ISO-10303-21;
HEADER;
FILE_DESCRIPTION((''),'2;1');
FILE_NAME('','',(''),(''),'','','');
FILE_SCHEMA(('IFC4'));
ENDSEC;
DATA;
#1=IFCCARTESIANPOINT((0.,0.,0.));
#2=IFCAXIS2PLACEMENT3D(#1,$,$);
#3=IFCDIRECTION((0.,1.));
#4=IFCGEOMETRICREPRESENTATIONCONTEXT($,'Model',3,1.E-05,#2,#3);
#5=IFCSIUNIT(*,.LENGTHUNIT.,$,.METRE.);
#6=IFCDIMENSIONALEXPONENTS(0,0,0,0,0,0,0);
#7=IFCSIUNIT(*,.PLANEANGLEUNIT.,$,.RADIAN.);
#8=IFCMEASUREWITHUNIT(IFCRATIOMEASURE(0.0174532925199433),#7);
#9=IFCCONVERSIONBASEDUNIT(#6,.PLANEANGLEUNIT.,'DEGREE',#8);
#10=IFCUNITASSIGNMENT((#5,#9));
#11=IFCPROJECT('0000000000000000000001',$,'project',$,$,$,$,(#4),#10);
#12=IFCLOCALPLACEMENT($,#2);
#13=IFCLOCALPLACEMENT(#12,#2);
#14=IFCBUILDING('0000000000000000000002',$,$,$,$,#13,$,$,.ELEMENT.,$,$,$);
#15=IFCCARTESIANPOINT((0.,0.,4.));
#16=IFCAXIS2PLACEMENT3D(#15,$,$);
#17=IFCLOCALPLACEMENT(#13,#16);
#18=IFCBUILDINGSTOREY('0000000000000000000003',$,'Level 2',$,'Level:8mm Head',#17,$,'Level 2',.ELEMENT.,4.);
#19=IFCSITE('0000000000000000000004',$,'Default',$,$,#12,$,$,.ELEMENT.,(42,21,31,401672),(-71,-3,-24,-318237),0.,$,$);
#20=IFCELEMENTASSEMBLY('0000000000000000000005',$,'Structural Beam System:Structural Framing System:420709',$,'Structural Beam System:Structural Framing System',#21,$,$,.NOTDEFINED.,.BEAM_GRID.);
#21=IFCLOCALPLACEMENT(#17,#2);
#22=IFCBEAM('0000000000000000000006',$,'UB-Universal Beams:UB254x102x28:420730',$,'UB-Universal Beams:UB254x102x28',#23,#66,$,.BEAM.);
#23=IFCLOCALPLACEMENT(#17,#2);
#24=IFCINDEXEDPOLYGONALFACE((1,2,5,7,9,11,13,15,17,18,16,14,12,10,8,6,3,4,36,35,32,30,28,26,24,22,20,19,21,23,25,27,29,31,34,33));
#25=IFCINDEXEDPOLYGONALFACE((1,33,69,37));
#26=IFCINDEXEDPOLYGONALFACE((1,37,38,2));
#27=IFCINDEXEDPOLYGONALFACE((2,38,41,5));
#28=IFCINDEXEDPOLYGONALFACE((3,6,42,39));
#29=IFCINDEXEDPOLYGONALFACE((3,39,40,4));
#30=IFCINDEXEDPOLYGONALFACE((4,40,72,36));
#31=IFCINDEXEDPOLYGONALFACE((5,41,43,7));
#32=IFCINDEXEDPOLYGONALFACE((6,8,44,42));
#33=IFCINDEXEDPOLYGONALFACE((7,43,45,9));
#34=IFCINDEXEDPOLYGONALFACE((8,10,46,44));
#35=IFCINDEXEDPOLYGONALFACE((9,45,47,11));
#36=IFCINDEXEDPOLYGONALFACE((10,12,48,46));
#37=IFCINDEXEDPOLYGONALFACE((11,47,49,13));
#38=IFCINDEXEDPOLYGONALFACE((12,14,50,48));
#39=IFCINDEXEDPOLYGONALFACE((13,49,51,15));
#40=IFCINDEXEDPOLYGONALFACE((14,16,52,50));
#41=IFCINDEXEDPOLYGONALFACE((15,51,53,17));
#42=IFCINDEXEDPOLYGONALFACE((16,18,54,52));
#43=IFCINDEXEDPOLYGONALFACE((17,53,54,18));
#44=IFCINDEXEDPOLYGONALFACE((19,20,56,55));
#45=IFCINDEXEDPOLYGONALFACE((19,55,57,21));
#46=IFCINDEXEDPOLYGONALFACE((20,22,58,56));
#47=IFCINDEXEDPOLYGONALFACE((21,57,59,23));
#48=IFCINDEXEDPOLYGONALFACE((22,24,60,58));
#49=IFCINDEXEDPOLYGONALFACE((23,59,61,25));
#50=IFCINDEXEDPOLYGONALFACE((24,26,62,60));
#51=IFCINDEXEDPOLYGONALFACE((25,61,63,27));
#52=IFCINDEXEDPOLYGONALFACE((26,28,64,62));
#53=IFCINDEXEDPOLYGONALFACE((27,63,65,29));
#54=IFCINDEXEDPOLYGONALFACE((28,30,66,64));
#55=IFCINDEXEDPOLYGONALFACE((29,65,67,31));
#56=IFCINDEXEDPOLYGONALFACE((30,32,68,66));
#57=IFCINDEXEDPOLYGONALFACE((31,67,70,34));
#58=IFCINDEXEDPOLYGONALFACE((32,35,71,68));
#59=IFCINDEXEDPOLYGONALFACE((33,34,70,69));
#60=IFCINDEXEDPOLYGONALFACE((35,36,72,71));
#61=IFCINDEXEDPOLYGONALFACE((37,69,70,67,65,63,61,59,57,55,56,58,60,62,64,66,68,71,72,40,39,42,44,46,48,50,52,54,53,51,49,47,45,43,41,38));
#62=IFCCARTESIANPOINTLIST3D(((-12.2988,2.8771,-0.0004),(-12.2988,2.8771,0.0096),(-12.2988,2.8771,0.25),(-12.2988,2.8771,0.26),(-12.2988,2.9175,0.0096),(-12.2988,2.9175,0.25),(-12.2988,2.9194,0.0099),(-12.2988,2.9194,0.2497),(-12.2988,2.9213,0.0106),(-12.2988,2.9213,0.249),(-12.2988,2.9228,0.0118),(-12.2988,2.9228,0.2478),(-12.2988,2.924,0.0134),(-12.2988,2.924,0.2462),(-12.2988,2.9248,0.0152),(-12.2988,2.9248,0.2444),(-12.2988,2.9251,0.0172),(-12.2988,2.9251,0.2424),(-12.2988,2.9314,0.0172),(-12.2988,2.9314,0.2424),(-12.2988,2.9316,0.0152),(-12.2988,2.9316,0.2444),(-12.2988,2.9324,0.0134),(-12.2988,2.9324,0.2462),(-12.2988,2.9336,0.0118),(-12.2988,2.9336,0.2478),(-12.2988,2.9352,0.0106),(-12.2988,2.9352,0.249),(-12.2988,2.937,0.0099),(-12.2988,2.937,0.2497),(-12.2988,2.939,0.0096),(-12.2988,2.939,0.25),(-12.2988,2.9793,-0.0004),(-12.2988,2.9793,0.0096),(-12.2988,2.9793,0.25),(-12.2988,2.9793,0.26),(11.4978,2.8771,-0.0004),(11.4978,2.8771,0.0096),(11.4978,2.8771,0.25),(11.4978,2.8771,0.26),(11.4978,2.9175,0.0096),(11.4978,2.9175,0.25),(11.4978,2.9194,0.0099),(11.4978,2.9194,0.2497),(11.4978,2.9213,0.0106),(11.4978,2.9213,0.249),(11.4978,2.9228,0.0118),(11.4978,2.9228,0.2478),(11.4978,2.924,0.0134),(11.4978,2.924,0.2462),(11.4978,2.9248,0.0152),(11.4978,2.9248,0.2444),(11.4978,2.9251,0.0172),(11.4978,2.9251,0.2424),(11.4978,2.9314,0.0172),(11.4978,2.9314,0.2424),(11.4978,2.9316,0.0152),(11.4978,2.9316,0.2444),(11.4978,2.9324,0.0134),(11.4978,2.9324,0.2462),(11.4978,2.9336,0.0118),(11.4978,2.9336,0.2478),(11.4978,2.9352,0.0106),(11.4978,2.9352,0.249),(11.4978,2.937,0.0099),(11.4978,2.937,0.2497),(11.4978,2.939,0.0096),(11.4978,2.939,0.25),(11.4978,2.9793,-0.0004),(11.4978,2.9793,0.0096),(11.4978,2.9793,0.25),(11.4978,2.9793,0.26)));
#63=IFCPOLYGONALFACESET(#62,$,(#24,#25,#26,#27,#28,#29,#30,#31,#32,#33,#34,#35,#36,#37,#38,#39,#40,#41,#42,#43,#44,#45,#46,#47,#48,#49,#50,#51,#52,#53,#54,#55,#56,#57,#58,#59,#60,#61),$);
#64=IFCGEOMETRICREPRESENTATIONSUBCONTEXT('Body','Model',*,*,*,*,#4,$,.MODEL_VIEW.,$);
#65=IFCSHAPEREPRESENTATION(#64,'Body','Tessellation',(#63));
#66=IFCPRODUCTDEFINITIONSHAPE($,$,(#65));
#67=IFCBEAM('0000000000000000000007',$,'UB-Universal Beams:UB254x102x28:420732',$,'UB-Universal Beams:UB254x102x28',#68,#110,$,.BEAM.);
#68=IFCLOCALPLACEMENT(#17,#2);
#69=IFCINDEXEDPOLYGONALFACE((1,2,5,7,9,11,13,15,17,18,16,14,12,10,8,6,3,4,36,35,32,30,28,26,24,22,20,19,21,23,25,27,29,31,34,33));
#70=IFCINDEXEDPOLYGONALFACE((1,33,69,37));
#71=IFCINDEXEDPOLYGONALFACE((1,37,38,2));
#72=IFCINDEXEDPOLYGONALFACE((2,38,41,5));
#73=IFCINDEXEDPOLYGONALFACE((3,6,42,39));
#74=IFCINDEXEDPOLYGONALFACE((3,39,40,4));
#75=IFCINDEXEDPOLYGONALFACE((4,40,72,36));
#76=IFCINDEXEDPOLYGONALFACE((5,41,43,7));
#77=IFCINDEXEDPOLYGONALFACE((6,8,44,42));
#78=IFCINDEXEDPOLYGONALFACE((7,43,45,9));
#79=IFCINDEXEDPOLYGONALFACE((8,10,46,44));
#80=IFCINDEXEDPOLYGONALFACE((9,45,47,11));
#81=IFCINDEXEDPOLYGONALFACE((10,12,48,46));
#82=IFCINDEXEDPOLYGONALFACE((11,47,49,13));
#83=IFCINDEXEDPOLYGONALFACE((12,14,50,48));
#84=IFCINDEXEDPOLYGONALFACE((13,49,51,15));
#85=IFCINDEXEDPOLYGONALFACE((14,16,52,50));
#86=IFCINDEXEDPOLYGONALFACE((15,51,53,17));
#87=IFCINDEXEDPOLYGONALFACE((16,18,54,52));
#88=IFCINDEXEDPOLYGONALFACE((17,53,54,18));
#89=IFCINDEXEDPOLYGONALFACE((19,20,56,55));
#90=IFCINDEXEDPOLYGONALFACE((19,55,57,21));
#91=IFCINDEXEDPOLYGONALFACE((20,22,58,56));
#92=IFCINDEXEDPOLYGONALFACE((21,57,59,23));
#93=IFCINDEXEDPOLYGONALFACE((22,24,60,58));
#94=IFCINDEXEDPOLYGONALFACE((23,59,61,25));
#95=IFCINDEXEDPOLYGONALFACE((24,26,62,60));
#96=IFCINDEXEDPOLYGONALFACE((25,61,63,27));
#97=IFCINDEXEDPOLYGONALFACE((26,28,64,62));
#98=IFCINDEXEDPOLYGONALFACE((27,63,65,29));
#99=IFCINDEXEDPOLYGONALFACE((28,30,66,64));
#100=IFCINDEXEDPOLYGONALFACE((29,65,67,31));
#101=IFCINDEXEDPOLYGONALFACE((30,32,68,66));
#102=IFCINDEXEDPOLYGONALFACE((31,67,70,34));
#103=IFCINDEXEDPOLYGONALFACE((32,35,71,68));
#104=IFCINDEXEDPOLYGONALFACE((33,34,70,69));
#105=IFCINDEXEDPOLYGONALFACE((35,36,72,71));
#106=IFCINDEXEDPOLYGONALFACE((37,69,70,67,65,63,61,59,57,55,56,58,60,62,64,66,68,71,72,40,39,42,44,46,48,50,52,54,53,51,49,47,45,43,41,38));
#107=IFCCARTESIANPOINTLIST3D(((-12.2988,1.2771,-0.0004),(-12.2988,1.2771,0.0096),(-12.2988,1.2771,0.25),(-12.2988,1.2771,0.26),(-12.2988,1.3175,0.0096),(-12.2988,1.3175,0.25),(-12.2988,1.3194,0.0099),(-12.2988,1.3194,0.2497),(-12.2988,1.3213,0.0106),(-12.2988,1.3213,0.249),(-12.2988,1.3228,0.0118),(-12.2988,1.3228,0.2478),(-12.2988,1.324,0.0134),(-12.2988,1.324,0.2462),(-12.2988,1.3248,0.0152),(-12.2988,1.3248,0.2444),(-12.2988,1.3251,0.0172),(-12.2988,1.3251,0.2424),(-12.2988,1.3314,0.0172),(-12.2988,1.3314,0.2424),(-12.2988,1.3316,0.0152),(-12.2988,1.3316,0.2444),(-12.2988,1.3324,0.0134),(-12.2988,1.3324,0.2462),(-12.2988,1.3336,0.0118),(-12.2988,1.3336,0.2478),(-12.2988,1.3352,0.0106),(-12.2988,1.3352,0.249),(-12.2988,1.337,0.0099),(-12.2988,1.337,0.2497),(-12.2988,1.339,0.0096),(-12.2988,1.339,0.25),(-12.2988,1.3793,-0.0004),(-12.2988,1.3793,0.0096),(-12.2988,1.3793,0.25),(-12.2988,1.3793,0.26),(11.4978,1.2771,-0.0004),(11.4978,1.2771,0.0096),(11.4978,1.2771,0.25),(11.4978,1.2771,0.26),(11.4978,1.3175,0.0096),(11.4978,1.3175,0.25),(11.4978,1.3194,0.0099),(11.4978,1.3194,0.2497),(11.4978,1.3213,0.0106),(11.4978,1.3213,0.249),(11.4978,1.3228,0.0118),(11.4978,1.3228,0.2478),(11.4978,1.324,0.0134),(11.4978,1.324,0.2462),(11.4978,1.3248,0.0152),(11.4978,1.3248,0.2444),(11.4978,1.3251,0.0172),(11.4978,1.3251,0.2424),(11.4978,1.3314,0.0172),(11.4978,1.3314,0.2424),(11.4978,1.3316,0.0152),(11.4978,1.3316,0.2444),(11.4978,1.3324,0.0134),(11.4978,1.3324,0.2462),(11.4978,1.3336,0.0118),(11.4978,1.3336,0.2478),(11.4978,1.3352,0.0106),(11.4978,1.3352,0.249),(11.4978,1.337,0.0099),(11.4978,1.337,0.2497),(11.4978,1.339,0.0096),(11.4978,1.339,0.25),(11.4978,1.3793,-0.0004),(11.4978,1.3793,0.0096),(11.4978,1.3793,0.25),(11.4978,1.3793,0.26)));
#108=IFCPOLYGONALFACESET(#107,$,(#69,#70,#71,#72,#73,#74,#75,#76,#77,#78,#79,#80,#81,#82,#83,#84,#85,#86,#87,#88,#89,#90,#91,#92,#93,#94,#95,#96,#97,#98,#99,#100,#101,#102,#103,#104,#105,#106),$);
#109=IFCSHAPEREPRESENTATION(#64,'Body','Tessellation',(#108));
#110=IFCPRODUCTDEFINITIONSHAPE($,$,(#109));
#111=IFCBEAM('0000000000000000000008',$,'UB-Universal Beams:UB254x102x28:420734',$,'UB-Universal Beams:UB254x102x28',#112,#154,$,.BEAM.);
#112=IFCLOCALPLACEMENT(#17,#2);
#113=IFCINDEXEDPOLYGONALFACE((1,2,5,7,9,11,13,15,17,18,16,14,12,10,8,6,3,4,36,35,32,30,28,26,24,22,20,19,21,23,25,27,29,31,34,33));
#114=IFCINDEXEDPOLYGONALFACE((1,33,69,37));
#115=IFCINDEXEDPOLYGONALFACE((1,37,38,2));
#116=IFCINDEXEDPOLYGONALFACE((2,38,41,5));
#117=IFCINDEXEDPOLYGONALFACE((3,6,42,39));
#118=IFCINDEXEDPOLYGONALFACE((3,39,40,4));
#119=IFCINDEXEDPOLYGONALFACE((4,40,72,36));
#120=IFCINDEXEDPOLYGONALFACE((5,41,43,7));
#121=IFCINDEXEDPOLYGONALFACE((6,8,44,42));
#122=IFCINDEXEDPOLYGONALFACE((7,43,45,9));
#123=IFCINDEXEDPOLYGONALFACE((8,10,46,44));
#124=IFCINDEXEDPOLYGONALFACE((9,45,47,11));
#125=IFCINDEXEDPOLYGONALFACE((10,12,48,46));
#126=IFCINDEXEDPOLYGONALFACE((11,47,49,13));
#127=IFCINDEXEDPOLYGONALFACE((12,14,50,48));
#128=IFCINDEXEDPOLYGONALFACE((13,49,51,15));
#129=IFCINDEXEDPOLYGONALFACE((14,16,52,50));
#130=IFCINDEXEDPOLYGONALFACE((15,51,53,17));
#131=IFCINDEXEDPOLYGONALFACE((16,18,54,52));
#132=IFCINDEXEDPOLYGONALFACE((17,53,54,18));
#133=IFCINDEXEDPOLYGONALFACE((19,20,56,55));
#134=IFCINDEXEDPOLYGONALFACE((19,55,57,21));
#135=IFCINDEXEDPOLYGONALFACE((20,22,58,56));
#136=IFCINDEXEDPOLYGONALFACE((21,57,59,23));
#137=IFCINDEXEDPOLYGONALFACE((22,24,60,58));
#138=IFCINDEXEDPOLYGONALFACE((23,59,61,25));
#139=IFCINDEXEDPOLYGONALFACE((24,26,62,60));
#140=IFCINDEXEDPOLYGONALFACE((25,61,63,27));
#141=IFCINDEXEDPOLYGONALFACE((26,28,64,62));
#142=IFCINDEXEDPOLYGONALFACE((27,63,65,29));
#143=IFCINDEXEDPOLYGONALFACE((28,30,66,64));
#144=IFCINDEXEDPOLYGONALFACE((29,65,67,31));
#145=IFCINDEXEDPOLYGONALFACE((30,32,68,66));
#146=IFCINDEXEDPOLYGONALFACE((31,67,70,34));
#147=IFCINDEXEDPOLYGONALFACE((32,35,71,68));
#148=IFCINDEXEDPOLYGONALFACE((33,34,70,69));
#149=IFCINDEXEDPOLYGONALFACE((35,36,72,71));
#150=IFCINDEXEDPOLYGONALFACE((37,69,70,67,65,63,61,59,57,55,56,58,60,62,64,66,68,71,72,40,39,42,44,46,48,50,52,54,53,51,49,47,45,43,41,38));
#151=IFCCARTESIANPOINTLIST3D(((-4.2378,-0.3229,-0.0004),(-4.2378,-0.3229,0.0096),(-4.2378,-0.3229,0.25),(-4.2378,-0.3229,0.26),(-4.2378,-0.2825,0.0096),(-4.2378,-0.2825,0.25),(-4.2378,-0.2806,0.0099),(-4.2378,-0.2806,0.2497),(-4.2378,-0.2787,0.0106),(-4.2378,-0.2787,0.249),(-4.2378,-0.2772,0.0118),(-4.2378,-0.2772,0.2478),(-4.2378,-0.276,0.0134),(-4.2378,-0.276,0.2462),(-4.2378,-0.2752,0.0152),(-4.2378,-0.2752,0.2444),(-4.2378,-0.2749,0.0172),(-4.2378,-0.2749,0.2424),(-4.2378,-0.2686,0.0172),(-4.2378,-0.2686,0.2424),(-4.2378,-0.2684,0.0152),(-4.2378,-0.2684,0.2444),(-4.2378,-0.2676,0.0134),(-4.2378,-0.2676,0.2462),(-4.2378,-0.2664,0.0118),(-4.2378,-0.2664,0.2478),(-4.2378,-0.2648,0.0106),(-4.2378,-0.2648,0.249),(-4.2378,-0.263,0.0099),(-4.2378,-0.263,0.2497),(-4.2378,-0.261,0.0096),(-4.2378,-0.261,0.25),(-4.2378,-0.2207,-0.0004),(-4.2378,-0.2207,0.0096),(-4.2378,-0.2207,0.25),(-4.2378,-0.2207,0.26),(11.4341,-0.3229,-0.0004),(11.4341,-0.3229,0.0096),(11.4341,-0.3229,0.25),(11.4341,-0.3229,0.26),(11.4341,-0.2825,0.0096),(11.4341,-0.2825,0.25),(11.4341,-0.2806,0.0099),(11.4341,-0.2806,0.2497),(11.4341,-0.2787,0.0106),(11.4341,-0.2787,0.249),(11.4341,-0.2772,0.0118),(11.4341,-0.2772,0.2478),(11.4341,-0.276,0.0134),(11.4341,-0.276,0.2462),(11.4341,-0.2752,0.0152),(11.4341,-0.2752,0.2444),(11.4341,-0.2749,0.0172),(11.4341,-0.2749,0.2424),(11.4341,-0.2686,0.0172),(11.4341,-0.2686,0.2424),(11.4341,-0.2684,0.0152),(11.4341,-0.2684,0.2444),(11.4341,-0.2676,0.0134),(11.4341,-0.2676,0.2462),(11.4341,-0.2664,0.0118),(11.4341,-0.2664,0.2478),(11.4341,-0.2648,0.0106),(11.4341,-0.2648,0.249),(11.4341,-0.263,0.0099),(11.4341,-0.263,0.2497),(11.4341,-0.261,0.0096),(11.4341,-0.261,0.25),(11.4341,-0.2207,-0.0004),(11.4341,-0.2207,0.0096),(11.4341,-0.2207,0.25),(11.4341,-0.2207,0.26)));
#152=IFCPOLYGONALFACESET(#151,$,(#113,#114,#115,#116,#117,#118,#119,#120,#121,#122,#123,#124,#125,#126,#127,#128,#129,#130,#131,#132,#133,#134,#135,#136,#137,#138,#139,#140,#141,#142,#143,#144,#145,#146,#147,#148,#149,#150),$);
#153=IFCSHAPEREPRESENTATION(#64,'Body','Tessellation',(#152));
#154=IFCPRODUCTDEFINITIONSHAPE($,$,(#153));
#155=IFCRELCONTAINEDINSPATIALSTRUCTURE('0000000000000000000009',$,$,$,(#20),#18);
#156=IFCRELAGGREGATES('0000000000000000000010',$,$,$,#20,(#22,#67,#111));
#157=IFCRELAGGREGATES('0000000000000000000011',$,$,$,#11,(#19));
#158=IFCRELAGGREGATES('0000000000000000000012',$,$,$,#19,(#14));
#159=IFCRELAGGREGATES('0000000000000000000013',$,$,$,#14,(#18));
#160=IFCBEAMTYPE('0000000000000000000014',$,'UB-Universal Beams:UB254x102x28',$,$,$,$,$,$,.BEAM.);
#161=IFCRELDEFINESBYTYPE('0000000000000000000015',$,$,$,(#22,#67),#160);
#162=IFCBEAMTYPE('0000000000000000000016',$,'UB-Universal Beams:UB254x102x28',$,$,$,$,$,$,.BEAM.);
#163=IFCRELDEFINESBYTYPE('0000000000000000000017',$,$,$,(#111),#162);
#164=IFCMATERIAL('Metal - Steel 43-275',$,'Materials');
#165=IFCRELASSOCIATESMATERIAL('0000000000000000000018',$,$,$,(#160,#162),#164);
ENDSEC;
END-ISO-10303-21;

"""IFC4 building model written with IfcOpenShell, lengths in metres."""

from ifc_helpers import new_model, entity, si_unit, converted_unit, direction, frame, frame_2d, origin, place, context, subcontext, project, spatial, i_section, extrude, source, transform, mapped, material, material_profile, profile_set, type_object, type_shapes, element, aggregate, save


model = new_model("IFC4")

# Units and contexts
model_context = context("Model", 3, precision=1e-05, world=origin(), true_north=direction((0.0, 1.0)))
body_context = subcontext(model_context, "Body", "Model", "MODEL_VIEW")
ifc_project = project(units=[si_unit("LENGTHUNIT", "METRE"), converted_unit("PLANEANGLEUNIT", "DEGREE", entity("IfcRatioMeasure", 0.0174532925199433), si_unit("PLANEANGLEUNIT", "RADIAN"), dimensions=[0, 0, 0, 0, 0, 0, 0])], contexts=[model_context])

# Site, building, storey
site_placement = place(None, origin())
site = spatial("IfcSite", under=ifc_project, at=site_placement, Name="Default", CompositionType="ELEMENT", RefLatitude=(42, 21, 31, 401672), RefLongitude=(-71, -3, -24, -318237), RefElevation=0.0)
building_placement = place(site_placement, origin())
building = spatial("IfcBuilding", under=site, at=building_placement, CompositionType="ELEMENT")
storey_placement = place(building_placement, frame((0.0, 0.0, 4.0)))
storey = spatial("IfcBuildingStorey", under=building, at=storey_placement, Name="Level 2", ObjectType="Level:8mm Head", LongName="Level 2", CompositionType="ELEMENT", Elevation=4.0)

# Shared definitions
ifc_material_1 = material(Name="Metal - Steel 43-275", Category="Materials")

# Element assembly, beams
assembly_placement = place(storey_placement, origin())
assembly = element("IfcElementAssembly", 1, at=assembly_placement, inside=storey, Name="Structural Beam System:Structural Framing System:420709", ObjectType="Structural Beam System:Structural Framing System", AssemblyPlace="NOTDEFINED", PredefinedType="BEAM_GRID")
ifc_material_profile_1 = material_profile(ifc_material_1, i_section(OverallWidth=0.1022, OverallDepth=0.2604, WebThickness=0.0063, FlangeThickness=0.01, FilletRadius=0.0076, at=frame_2d((0.0, 0.0), x_axis=(0.0, 1.0))), Name="UB254x102x28")
ifc_profile_set_1 = profile_set([ifc_material_profile_1], Name="UB254x102x28")
beam_type_1 = type_object("IfcBeamType", Name="UB-Universal Beams:UB254x102x28", PredefinedType="BEAM", material=ifc_profile_set_1)
shared_shape_1 = source(origin(), body_context, "Body", "SweptSolid", [
    extrude(i_section(OverallWidth=0.1022, OverallDepth=0.2604, WebThickness=0.0063, FlangeThickness=0.01, FilletRadius=0.0076, at=frame_2d((0.0, 0.0), x_axis=(0.0, 1.0))), frame((-11.8983, 0.0, 0.0), z_axis=(1.0, 0.0, 0.0), x_axis=(0.0, 0.0, -1.0)), (0.0, 0.0, 1.0), 23.7966),
])
type_shapes(beam_type_1, [shared_shape_1])
beam_1_placement = place(assembly_placement, frame((-0.4005, 2.9282, 0.1298)))
beam_1 = element("IfcBeam", 2, at=beam_1_placement, type_object=beam_type_1, Name="UB-Universal Beams:UB254x102x28:420730", ObjectType="UB-Universal Beams:UB254x102x28", PredefinedType="BEAM", context=body_context, shape_type="MappedRepresentation", body=[
    mapped(shared_shape_1, transform((0.0, 0.0, 0.0), scale=1.0)),
])
beam_2_placement = place(assembly_placement, frame((-0.4005, 1.3282, 0.1298)))
beam_2 = element("IfcBeam", 3, at=beam_2_placement, type_object=beam_type_1, Name="UB-Universal Beams:UB254x102x28:420732", ObjectType="UB-Universal Beams:UB254x102x28", PredefinedType="BEAM", context=body_context, shape_type="MappedRepresentation", body=[
    mapped(shared_shape_1, transform((0.0, 0.0, 0.0), scale=1.0)),
])
beam_type_2 = type_object("IfcBeamType", Name="UB-Universal Beams:UB254x102x28", PredefinedType="BEAM", material=ifc_profile_set_1)
shared_shape_2 = source(origin(), body_context, "Body", "SweptSolid", [
    extrude(i_section(OverallWidth=0.1022, OverallDepth=0.2604, WebThickness=0.0063, FlangeThickness=0.01, FilletRadius=0.0076, at=frame_2d((0.0, 0.0), x_axis=(0.0, 1.0))), frame((-7.8818, 0.0, 0.0), z_axis=(1.0, 0.0, 0.0), x_axis=(0.0, 0.0, -1.0)), (0.0, 0.0, 1.0), 15.6719),
])
type_shapes(beam_type_2, [shared_shape_2])
beam_3_placement = place(assembly_placement, frame((3.644, -0.2718, 0.1298)))
beam_3 = element("IfcBeam", 4, at=beam_3_placement, type_object=beam_type_2, Name="UB-Universal Beams:UB254x102x28:420734", ObjectType="UB-Universal Beams:UB254x102x28", PredefinedType="BEAM", context=body_context, shape_type="MappedRepresentation", body=[
    mapped(shared_shape_2, transform((0.0, 0.0, 0.0), scale=1.0)),
])
aggregate(assembly, [beam_1, beam_2, beam_3])

save(model, "model.ifc")
